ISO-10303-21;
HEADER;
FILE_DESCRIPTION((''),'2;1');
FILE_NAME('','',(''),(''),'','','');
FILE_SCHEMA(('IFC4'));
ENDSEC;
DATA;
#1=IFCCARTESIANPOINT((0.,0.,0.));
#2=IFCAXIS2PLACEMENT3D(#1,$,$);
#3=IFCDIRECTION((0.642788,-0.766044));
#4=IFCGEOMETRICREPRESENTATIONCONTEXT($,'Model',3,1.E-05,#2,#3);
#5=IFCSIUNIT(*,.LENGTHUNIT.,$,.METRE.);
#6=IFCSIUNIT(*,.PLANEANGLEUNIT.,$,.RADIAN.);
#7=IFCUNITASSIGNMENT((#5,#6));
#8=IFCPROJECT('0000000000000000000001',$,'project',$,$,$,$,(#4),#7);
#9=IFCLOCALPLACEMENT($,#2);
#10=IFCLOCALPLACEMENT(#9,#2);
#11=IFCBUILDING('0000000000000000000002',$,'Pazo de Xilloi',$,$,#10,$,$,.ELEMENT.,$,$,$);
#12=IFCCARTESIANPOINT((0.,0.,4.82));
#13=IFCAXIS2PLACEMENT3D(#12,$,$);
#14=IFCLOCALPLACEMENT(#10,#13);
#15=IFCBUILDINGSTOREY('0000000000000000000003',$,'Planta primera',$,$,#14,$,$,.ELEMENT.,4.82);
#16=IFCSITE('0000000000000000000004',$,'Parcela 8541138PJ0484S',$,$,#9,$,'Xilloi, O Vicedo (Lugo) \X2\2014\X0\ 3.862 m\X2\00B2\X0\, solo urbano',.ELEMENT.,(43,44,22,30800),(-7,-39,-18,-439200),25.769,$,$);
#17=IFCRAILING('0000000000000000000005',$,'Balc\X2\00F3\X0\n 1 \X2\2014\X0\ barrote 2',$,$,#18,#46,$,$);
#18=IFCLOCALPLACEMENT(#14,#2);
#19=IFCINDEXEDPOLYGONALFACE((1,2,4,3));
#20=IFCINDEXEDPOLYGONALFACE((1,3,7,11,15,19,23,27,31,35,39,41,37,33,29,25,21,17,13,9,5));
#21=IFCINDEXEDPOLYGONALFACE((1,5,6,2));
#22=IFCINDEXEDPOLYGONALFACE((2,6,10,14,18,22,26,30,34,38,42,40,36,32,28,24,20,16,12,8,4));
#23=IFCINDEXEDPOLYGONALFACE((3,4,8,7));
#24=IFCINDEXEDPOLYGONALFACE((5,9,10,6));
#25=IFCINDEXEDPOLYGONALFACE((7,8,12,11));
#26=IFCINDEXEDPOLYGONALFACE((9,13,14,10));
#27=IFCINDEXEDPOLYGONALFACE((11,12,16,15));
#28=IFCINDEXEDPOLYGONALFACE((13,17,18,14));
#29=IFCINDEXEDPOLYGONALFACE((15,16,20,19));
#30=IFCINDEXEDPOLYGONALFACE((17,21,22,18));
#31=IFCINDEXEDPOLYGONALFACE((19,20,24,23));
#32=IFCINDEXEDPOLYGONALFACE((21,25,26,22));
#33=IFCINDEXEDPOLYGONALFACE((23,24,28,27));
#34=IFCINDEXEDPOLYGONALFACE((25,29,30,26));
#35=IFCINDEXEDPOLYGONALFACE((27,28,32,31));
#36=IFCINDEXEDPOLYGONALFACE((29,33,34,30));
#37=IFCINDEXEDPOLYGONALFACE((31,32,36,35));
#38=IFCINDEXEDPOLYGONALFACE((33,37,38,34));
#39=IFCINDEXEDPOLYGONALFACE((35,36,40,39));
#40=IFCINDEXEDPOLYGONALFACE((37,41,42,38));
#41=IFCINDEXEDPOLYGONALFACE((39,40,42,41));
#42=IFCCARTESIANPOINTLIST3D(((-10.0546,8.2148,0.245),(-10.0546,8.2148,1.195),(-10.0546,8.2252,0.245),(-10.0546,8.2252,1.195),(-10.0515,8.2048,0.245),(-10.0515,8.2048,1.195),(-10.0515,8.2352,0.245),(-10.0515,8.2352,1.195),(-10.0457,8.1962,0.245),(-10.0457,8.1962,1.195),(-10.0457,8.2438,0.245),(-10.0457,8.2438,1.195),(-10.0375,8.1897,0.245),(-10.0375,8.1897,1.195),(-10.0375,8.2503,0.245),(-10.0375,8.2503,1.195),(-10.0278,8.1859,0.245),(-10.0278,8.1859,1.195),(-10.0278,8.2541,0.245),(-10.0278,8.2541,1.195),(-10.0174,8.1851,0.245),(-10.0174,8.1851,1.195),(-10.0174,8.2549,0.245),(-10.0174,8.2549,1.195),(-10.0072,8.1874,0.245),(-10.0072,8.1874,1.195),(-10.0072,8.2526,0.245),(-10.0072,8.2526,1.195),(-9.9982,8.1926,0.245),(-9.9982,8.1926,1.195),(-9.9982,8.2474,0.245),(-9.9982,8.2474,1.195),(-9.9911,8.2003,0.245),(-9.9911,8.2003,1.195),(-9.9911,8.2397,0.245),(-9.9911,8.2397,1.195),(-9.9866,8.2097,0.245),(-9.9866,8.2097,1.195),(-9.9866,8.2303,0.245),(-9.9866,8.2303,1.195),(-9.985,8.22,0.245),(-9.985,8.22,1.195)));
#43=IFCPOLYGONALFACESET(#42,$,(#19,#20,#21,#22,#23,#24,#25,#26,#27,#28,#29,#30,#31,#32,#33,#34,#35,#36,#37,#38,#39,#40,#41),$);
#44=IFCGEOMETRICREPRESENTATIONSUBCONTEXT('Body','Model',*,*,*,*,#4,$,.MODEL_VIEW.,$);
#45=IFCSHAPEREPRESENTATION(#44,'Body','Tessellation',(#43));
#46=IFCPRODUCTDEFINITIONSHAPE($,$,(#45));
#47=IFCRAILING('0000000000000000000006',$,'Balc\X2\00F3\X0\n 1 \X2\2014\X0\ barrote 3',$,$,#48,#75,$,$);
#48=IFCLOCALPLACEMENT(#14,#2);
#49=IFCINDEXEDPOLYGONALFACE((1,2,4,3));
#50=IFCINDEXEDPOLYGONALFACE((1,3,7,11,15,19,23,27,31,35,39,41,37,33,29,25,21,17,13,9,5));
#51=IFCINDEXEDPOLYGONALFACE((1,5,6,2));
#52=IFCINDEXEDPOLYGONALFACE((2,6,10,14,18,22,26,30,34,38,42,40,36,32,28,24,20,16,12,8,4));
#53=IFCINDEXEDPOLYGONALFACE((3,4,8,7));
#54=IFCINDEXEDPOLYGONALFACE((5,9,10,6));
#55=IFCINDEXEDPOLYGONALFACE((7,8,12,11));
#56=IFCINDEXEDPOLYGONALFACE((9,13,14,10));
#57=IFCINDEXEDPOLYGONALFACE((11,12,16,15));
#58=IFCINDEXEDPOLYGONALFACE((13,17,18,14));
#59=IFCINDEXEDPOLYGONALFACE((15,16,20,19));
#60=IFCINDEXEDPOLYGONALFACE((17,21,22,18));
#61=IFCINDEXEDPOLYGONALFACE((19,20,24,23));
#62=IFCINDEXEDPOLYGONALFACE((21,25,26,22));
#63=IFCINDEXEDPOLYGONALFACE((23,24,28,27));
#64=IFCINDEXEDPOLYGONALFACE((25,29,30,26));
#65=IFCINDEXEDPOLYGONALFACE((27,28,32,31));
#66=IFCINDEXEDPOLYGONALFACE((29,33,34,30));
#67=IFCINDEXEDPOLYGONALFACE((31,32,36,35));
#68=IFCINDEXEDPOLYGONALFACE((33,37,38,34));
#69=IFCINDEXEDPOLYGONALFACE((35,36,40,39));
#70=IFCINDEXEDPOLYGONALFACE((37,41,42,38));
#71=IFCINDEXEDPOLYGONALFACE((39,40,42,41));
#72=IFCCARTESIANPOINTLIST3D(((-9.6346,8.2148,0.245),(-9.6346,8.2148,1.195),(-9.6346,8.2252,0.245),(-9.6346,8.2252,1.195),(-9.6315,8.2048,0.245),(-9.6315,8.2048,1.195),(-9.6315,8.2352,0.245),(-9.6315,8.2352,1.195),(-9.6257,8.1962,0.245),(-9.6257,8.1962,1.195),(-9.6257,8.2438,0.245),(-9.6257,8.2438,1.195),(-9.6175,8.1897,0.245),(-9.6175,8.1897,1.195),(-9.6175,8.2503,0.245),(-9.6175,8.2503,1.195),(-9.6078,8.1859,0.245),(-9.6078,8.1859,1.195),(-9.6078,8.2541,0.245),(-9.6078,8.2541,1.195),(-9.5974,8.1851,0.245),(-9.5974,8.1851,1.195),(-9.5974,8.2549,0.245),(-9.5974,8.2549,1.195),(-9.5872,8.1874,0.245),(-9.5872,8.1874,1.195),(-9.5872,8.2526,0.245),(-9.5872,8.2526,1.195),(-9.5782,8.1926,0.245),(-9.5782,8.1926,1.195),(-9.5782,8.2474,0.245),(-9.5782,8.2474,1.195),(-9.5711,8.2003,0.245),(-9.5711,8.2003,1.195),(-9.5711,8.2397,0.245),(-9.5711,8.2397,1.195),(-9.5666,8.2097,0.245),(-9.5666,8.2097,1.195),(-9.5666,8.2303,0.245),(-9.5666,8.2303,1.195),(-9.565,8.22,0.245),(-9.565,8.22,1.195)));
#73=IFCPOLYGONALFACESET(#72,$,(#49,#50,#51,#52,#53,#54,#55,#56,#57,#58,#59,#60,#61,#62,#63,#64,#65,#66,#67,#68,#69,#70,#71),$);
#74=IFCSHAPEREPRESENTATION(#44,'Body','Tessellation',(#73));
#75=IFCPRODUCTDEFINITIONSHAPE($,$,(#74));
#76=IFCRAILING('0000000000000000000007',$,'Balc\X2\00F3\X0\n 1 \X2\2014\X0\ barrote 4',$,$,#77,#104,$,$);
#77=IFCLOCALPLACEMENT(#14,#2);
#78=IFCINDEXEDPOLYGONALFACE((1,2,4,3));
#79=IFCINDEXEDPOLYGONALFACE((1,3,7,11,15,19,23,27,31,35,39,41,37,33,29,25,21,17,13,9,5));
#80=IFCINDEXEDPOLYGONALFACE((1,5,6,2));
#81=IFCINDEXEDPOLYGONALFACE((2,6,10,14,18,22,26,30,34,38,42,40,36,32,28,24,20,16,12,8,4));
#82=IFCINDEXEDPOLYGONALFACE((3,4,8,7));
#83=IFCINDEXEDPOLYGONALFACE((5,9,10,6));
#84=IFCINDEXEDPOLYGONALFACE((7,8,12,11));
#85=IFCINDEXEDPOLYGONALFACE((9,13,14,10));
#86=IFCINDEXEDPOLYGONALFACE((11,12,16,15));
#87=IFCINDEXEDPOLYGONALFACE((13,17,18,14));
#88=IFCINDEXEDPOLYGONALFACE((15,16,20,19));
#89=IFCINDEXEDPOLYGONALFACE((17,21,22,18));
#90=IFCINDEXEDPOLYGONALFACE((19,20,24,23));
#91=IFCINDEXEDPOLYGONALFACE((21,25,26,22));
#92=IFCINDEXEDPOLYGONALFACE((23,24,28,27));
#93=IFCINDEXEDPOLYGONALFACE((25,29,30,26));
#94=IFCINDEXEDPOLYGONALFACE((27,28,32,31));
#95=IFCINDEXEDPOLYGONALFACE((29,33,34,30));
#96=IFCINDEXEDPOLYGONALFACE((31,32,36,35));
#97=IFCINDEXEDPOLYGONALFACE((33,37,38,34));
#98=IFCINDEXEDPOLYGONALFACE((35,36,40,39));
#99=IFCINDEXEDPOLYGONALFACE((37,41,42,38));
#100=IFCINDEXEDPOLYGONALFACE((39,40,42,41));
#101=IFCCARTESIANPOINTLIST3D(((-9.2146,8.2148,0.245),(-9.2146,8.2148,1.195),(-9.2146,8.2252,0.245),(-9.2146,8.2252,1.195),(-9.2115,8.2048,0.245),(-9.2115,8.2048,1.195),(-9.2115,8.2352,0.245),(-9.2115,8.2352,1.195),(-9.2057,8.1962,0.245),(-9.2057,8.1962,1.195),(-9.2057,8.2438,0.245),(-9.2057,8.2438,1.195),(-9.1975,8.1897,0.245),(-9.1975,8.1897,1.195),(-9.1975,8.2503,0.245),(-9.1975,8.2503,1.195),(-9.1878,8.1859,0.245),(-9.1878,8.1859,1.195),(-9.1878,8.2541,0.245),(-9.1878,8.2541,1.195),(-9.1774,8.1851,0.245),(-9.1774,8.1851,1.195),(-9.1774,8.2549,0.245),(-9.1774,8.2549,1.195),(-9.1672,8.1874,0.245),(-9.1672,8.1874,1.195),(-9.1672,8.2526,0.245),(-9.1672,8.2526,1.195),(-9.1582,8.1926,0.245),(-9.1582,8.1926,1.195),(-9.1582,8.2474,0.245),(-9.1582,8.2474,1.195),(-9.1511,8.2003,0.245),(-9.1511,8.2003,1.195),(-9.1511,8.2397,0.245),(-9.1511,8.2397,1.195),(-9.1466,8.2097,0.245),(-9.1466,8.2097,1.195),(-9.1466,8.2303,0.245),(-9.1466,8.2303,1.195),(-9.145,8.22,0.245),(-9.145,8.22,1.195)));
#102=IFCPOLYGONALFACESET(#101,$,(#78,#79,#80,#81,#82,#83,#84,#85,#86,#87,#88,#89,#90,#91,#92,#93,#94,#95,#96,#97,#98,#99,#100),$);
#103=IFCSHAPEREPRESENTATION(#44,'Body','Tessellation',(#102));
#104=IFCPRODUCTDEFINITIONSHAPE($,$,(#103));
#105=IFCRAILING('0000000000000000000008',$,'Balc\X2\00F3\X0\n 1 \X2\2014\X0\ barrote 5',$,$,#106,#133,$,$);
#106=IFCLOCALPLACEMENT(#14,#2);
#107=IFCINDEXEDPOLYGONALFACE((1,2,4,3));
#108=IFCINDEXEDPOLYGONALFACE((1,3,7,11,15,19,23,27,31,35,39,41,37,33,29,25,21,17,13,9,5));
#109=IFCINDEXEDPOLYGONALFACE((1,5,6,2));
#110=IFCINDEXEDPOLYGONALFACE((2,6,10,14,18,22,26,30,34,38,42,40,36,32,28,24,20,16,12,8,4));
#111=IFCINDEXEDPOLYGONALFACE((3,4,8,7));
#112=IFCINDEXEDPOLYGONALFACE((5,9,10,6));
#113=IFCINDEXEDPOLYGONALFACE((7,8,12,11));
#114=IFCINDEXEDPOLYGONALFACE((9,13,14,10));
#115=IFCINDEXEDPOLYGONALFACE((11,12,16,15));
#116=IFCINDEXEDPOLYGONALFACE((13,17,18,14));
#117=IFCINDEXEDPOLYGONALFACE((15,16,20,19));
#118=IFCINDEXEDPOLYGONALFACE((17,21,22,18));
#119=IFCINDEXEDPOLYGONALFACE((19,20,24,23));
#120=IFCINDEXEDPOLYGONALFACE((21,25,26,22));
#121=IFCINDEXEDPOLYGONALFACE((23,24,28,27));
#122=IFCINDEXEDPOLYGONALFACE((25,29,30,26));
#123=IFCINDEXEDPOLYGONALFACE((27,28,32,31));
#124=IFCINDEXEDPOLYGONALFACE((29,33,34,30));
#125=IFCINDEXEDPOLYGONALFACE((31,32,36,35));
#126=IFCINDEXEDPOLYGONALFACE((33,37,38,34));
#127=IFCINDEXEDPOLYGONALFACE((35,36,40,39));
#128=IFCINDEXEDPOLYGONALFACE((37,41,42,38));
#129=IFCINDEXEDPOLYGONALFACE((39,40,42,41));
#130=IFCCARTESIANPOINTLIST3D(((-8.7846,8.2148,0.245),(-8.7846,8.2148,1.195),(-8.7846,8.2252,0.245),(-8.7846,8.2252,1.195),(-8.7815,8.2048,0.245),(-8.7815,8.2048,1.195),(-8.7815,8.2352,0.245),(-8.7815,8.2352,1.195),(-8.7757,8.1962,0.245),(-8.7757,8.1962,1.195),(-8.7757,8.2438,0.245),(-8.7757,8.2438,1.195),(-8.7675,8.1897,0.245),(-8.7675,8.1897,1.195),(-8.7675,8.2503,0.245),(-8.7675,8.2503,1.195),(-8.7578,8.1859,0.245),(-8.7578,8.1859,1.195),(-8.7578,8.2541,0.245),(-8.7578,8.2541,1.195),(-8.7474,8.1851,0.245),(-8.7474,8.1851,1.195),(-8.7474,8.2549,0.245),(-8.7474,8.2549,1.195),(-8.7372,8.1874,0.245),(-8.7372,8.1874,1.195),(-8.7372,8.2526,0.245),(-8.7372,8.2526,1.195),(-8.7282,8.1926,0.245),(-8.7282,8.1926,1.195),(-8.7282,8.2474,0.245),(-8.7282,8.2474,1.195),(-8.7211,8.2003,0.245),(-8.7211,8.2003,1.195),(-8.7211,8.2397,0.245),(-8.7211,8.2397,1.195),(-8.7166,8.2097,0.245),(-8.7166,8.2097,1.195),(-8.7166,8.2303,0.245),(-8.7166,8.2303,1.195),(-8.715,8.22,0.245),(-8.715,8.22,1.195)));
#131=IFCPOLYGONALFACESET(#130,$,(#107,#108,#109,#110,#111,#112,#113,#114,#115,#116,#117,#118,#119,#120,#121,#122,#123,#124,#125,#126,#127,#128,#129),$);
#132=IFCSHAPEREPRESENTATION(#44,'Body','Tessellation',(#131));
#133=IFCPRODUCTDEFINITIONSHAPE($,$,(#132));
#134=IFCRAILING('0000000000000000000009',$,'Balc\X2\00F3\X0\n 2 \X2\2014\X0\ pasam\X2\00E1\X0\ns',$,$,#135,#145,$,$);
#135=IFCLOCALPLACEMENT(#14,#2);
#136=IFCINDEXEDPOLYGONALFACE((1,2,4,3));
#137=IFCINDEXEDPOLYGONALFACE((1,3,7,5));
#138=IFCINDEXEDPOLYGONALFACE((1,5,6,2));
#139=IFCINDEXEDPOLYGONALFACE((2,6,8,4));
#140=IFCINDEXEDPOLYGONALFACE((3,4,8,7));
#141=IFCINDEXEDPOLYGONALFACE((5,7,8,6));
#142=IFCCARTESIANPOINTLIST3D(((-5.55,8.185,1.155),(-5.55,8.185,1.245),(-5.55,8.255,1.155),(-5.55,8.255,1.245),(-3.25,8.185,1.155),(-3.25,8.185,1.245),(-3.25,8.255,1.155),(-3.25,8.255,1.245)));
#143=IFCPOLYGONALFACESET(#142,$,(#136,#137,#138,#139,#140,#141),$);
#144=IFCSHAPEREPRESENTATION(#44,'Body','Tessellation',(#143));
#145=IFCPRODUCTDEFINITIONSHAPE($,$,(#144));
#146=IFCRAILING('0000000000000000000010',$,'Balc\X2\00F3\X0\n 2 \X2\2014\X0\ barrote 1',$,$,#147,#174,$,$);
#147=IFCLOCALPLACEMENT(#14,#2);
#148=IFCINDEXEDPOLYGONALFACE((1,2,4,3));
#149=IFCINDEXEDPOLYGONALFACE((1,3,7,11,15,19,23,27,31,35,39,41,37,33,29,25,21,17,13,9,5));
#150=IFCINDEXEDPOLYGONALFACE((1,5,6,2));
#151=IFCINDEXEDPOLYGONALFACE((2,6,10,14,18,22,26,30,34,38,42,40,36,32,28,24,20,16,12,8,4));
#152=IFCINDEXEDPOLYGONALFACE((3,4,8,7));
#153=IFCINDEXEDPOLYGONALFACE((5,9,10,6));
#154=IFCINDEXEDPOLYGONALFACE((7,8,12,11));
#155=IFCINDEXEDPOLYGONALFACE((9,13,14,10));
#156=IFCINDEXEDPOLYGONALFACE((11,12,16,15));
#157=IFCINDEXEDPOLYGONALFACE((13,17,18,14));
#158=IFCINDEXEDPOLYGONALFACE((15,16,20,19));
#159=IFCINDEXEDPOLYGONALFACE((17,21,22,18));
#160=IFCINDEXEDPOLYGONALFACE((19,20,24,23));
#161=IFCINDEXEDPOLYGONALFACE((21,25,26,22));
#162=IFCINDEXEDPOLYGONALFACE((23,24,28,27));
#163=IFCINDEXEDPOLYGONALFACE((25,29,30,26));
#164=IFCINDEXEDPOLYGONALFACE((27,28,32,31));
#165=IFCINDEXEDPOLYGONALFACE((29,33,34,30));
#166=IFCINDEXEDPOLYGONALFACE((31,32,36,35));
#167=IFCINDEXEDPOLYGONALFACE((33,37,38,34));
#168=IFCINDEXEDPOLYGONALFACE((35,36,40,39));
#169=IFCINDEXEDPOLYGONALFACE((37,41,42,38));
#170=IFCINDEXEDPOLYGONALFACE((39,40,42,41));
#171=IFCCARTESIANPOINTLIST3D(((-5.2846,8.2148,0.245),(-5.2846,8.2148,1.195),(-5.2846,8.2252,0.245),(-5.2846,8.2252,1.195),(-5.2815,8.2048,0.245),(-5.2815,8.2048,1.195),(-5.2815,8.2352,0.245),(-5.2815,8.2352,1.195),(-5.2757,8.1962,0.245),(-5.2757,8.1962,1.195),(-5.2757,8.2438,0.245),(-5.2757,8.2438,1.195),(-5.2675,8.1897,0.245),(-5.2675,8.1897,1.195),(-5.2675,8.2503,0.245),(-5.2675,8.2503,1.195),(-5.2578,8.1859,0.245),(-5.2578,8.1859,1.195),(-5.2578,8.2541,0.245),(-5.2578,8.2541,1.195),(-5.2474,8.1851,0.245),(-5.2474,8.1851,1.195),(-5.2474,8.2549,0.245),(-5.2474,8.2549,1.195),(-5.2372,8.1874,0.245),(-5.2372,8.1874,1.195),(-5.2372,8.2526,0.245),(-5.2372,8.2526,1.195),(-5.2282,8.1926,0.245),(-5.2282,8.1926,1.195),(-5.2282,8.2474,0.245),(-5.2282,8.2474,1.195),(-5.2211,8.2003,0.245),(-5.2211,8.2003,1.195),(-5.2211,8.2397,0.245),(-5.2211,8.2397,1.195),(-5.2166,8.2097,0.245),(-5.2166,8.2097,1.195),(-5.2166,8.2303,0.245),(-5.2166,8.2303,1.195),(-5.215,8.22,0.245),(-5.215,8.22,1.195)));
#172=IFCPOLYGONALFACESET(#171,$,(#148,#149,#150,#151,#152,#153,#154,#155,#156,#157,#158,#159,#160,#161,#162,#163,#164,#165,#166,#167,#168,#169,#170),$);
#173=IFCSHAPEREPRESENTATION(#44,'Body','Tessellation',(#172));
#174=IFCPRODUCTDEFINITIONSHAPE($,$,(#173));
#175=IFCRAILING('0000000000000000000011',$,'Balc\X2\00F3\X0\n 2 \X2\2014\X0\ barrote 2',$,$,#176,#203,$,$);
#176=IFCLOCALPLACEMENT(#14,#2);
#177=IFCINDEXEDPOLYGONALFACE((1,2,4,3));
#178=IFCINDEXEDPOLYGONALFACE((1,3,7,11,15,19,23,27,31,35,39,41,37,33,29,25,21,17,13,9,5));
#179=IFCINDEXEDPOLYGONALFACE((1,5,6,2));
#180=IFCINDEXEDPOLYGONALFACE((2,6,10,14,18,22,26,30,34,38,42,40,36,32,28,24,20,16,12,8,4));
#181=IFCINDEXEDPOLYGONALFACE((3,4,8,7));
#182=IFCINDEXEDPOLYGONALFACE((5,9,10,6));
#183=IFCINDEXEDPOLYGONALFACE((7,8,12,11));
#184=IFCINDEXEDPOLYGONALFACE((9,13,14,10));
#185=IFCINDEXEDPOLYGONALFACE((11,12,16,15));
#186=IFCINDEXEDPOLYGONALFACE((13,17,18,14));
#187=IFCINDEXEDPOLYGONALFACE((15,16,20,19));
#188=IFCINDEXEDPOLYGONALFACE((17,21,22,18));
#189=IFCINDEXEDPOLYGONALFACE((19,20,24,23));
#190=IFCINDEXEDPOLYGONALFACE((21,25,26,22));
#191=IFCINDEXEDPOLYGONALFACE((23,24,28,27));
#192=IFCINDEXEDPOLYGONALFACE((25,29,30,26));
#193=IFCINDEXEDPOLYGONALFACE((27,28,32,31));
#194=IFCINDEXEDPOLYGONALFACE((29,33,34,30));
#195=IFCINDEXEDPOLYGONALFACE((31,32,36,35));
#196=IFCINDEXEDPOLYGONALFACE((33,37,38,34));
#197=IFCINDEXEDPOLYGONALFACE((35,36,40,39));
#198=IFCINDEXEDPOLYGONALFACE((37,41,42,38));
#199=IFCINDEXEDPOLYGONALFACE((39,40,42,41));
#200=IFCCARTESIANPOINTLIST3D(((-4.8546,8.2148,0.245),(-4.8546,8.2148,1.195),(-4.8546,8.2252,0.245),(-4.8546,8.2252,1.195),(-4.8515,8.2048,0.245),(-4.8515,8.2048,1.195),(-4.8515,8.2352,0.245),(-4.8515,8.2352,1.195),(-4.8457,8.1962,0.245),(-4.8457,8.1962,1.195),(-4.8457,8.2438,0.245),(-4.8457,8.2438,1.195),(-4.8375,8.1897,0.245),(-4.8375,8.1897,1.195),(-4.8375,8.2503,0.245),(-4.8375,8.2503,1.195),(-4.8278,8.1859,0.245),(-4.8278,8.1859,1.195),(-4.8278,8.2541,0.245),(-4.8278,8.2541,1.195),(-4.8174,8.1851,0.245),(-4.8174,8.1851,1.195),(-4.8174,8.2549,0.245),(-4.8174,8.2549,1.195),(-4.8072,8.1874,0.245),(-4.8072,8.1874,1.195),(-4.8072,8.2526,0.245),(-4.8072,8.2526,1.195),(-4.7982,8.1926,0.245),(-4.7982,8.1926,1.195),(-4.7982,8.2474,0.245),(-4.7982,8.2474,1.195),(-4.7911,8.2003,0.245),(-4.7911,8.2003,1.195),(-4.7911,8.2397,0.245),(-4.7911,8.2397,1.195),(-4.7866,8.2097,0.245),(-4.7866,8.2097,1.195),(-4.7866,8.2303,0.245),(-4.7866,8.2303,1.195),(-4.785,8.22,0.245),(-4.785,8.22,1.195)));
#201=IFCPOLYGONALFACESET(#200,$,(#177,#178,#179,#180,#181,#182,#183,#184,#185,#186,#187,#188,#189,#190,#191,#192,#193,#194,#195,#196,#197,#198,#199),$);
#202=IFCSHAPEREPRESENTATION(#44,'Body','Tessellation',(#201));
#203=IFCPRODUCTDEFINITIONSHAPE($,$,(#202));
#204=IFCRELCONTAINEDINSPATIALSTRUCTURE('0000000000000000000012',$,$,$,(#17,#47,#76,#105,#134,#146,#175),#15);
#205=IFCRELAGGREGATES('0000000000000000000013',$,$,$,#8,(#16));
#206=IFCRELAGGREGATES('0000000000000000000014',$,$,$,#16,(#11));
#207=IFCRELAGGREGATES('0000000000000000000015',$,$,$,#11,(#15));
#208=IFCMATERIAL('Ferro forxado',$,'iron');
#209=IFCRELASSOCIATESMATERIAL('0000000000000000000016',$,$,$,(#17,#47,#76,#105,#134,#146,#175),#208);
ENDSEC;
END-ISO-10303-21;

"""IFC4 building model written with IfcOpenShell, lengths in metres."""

from ifc_helpers import new_model, si_unit, direction, frame, origin, origin_2d, place, context, subcontext, project, spatial, rectangle, circle, extrude, material, element, save


model = new_model("IFC4")

# Units and contexts
model_context = context("Model", 3, precision=1e-05, world=origin(), true_north=direction((0.642788, -0.766044)))
body_context = subcontext(model_context, "Body", "Model", "MODEL_VIEW")
ifc_project = project(units=[si_unit("LENGTHUNIT", "METRE"), si_unit("PLANEANGLEUNIT", "RADIAN")], contexts=[model_context])

# Site, building, storey
site_placement = place(None, origin())
site = spatial("IfcSite", under=ifc_project, at=site_placement, Name="Parcela 8541138PJ0484S", LongName="Xilloi, O Vicedo (Lugo) — 3.862 m², solo urbano", CompositionType="ELEMENT", RefLatitude=(43, 44, 22, 30800), RefLongitude=(-7, -39, -18, -439200), RefElevation=25.769)
building_placement = place(site_placement, origin())
building = spatial("IfcBuilding", under=site, at=building_placement, Name="Pazo de Xilloi", CompositionType="ELEMENT")
storey_placement = place(building_placement, frame((0.0, 0.0, 4.82)))
storey = spatial("IfcBuildingStorey", under=building, at=storey_placement, Name="Planta primera", CompositionType="ELEMENT", Elevation=4.82)

# Railings
ifc_material_1 = material(Name="Ferro forxado", Category="iron")
for number, where, name in (
    (1, (-10.02, 8.22, 0.72), "Balcón 1 — barrote 2"),
    (2, (-9.6, 8.22, 0.72), "Balcón 1 — barrote 3"),
    (3, (-9.18, 8.22, 0.72), "Balcón 1 — barrote 4"),
    (4, (-8.75, 8.22, 0.72), "Balcón 1 — barrote 5"),
):
    element("IfcRailing", number, at=place(storey_placement, frame(where)), inside=storey, material=ifc_material_1, Name=name, context=body_context, shape_type="SweptSolid", body=[
        extrude(circle(Radius=0.035, at=origin_2d()), frame((0.0, 0.0, -0.475)), (0.0, 0.0, 1.0), 0.95),
    ])
railing_1_placement = place(storey_placement, frame((-4.4, 8.22, 1.2)))
element("IfcRailing", 5, at=railing_1_placement, inside=storey, material=ifc_material_1, Name="Balcón 2 — pasamáns", context=body_context, shape_type="SweptSolid", body=[
    extrude(rectangle(XDim=2.3, YDim=0.07, at=origin_2d()), frame((0.0, 0.0, -0.045)), (0.0, 0.0, 1.0), 0.09),
])
for number, where, name in (
    (6, (-5.25, 8.22, 0.72), "Balcón 2 — barrote 1"),
    (7, (-4.82, 8.22, 0.72), "Balcón 2 — barrote 2"),
):
    element("IfcRailing", number, at=place(storey_placement, frame(where)), inside=storey, material=ifc_material_1, Name=name, context=body_context, shape_type="SweptSolid", body=[
        extrude(circle(Radius=0.035, at=origin_2d()), frame((0.0, 0.0, -0.475)), (0.0, 0.0, 1.0), 0.95),
    ])

save(model, "model.ifc")
